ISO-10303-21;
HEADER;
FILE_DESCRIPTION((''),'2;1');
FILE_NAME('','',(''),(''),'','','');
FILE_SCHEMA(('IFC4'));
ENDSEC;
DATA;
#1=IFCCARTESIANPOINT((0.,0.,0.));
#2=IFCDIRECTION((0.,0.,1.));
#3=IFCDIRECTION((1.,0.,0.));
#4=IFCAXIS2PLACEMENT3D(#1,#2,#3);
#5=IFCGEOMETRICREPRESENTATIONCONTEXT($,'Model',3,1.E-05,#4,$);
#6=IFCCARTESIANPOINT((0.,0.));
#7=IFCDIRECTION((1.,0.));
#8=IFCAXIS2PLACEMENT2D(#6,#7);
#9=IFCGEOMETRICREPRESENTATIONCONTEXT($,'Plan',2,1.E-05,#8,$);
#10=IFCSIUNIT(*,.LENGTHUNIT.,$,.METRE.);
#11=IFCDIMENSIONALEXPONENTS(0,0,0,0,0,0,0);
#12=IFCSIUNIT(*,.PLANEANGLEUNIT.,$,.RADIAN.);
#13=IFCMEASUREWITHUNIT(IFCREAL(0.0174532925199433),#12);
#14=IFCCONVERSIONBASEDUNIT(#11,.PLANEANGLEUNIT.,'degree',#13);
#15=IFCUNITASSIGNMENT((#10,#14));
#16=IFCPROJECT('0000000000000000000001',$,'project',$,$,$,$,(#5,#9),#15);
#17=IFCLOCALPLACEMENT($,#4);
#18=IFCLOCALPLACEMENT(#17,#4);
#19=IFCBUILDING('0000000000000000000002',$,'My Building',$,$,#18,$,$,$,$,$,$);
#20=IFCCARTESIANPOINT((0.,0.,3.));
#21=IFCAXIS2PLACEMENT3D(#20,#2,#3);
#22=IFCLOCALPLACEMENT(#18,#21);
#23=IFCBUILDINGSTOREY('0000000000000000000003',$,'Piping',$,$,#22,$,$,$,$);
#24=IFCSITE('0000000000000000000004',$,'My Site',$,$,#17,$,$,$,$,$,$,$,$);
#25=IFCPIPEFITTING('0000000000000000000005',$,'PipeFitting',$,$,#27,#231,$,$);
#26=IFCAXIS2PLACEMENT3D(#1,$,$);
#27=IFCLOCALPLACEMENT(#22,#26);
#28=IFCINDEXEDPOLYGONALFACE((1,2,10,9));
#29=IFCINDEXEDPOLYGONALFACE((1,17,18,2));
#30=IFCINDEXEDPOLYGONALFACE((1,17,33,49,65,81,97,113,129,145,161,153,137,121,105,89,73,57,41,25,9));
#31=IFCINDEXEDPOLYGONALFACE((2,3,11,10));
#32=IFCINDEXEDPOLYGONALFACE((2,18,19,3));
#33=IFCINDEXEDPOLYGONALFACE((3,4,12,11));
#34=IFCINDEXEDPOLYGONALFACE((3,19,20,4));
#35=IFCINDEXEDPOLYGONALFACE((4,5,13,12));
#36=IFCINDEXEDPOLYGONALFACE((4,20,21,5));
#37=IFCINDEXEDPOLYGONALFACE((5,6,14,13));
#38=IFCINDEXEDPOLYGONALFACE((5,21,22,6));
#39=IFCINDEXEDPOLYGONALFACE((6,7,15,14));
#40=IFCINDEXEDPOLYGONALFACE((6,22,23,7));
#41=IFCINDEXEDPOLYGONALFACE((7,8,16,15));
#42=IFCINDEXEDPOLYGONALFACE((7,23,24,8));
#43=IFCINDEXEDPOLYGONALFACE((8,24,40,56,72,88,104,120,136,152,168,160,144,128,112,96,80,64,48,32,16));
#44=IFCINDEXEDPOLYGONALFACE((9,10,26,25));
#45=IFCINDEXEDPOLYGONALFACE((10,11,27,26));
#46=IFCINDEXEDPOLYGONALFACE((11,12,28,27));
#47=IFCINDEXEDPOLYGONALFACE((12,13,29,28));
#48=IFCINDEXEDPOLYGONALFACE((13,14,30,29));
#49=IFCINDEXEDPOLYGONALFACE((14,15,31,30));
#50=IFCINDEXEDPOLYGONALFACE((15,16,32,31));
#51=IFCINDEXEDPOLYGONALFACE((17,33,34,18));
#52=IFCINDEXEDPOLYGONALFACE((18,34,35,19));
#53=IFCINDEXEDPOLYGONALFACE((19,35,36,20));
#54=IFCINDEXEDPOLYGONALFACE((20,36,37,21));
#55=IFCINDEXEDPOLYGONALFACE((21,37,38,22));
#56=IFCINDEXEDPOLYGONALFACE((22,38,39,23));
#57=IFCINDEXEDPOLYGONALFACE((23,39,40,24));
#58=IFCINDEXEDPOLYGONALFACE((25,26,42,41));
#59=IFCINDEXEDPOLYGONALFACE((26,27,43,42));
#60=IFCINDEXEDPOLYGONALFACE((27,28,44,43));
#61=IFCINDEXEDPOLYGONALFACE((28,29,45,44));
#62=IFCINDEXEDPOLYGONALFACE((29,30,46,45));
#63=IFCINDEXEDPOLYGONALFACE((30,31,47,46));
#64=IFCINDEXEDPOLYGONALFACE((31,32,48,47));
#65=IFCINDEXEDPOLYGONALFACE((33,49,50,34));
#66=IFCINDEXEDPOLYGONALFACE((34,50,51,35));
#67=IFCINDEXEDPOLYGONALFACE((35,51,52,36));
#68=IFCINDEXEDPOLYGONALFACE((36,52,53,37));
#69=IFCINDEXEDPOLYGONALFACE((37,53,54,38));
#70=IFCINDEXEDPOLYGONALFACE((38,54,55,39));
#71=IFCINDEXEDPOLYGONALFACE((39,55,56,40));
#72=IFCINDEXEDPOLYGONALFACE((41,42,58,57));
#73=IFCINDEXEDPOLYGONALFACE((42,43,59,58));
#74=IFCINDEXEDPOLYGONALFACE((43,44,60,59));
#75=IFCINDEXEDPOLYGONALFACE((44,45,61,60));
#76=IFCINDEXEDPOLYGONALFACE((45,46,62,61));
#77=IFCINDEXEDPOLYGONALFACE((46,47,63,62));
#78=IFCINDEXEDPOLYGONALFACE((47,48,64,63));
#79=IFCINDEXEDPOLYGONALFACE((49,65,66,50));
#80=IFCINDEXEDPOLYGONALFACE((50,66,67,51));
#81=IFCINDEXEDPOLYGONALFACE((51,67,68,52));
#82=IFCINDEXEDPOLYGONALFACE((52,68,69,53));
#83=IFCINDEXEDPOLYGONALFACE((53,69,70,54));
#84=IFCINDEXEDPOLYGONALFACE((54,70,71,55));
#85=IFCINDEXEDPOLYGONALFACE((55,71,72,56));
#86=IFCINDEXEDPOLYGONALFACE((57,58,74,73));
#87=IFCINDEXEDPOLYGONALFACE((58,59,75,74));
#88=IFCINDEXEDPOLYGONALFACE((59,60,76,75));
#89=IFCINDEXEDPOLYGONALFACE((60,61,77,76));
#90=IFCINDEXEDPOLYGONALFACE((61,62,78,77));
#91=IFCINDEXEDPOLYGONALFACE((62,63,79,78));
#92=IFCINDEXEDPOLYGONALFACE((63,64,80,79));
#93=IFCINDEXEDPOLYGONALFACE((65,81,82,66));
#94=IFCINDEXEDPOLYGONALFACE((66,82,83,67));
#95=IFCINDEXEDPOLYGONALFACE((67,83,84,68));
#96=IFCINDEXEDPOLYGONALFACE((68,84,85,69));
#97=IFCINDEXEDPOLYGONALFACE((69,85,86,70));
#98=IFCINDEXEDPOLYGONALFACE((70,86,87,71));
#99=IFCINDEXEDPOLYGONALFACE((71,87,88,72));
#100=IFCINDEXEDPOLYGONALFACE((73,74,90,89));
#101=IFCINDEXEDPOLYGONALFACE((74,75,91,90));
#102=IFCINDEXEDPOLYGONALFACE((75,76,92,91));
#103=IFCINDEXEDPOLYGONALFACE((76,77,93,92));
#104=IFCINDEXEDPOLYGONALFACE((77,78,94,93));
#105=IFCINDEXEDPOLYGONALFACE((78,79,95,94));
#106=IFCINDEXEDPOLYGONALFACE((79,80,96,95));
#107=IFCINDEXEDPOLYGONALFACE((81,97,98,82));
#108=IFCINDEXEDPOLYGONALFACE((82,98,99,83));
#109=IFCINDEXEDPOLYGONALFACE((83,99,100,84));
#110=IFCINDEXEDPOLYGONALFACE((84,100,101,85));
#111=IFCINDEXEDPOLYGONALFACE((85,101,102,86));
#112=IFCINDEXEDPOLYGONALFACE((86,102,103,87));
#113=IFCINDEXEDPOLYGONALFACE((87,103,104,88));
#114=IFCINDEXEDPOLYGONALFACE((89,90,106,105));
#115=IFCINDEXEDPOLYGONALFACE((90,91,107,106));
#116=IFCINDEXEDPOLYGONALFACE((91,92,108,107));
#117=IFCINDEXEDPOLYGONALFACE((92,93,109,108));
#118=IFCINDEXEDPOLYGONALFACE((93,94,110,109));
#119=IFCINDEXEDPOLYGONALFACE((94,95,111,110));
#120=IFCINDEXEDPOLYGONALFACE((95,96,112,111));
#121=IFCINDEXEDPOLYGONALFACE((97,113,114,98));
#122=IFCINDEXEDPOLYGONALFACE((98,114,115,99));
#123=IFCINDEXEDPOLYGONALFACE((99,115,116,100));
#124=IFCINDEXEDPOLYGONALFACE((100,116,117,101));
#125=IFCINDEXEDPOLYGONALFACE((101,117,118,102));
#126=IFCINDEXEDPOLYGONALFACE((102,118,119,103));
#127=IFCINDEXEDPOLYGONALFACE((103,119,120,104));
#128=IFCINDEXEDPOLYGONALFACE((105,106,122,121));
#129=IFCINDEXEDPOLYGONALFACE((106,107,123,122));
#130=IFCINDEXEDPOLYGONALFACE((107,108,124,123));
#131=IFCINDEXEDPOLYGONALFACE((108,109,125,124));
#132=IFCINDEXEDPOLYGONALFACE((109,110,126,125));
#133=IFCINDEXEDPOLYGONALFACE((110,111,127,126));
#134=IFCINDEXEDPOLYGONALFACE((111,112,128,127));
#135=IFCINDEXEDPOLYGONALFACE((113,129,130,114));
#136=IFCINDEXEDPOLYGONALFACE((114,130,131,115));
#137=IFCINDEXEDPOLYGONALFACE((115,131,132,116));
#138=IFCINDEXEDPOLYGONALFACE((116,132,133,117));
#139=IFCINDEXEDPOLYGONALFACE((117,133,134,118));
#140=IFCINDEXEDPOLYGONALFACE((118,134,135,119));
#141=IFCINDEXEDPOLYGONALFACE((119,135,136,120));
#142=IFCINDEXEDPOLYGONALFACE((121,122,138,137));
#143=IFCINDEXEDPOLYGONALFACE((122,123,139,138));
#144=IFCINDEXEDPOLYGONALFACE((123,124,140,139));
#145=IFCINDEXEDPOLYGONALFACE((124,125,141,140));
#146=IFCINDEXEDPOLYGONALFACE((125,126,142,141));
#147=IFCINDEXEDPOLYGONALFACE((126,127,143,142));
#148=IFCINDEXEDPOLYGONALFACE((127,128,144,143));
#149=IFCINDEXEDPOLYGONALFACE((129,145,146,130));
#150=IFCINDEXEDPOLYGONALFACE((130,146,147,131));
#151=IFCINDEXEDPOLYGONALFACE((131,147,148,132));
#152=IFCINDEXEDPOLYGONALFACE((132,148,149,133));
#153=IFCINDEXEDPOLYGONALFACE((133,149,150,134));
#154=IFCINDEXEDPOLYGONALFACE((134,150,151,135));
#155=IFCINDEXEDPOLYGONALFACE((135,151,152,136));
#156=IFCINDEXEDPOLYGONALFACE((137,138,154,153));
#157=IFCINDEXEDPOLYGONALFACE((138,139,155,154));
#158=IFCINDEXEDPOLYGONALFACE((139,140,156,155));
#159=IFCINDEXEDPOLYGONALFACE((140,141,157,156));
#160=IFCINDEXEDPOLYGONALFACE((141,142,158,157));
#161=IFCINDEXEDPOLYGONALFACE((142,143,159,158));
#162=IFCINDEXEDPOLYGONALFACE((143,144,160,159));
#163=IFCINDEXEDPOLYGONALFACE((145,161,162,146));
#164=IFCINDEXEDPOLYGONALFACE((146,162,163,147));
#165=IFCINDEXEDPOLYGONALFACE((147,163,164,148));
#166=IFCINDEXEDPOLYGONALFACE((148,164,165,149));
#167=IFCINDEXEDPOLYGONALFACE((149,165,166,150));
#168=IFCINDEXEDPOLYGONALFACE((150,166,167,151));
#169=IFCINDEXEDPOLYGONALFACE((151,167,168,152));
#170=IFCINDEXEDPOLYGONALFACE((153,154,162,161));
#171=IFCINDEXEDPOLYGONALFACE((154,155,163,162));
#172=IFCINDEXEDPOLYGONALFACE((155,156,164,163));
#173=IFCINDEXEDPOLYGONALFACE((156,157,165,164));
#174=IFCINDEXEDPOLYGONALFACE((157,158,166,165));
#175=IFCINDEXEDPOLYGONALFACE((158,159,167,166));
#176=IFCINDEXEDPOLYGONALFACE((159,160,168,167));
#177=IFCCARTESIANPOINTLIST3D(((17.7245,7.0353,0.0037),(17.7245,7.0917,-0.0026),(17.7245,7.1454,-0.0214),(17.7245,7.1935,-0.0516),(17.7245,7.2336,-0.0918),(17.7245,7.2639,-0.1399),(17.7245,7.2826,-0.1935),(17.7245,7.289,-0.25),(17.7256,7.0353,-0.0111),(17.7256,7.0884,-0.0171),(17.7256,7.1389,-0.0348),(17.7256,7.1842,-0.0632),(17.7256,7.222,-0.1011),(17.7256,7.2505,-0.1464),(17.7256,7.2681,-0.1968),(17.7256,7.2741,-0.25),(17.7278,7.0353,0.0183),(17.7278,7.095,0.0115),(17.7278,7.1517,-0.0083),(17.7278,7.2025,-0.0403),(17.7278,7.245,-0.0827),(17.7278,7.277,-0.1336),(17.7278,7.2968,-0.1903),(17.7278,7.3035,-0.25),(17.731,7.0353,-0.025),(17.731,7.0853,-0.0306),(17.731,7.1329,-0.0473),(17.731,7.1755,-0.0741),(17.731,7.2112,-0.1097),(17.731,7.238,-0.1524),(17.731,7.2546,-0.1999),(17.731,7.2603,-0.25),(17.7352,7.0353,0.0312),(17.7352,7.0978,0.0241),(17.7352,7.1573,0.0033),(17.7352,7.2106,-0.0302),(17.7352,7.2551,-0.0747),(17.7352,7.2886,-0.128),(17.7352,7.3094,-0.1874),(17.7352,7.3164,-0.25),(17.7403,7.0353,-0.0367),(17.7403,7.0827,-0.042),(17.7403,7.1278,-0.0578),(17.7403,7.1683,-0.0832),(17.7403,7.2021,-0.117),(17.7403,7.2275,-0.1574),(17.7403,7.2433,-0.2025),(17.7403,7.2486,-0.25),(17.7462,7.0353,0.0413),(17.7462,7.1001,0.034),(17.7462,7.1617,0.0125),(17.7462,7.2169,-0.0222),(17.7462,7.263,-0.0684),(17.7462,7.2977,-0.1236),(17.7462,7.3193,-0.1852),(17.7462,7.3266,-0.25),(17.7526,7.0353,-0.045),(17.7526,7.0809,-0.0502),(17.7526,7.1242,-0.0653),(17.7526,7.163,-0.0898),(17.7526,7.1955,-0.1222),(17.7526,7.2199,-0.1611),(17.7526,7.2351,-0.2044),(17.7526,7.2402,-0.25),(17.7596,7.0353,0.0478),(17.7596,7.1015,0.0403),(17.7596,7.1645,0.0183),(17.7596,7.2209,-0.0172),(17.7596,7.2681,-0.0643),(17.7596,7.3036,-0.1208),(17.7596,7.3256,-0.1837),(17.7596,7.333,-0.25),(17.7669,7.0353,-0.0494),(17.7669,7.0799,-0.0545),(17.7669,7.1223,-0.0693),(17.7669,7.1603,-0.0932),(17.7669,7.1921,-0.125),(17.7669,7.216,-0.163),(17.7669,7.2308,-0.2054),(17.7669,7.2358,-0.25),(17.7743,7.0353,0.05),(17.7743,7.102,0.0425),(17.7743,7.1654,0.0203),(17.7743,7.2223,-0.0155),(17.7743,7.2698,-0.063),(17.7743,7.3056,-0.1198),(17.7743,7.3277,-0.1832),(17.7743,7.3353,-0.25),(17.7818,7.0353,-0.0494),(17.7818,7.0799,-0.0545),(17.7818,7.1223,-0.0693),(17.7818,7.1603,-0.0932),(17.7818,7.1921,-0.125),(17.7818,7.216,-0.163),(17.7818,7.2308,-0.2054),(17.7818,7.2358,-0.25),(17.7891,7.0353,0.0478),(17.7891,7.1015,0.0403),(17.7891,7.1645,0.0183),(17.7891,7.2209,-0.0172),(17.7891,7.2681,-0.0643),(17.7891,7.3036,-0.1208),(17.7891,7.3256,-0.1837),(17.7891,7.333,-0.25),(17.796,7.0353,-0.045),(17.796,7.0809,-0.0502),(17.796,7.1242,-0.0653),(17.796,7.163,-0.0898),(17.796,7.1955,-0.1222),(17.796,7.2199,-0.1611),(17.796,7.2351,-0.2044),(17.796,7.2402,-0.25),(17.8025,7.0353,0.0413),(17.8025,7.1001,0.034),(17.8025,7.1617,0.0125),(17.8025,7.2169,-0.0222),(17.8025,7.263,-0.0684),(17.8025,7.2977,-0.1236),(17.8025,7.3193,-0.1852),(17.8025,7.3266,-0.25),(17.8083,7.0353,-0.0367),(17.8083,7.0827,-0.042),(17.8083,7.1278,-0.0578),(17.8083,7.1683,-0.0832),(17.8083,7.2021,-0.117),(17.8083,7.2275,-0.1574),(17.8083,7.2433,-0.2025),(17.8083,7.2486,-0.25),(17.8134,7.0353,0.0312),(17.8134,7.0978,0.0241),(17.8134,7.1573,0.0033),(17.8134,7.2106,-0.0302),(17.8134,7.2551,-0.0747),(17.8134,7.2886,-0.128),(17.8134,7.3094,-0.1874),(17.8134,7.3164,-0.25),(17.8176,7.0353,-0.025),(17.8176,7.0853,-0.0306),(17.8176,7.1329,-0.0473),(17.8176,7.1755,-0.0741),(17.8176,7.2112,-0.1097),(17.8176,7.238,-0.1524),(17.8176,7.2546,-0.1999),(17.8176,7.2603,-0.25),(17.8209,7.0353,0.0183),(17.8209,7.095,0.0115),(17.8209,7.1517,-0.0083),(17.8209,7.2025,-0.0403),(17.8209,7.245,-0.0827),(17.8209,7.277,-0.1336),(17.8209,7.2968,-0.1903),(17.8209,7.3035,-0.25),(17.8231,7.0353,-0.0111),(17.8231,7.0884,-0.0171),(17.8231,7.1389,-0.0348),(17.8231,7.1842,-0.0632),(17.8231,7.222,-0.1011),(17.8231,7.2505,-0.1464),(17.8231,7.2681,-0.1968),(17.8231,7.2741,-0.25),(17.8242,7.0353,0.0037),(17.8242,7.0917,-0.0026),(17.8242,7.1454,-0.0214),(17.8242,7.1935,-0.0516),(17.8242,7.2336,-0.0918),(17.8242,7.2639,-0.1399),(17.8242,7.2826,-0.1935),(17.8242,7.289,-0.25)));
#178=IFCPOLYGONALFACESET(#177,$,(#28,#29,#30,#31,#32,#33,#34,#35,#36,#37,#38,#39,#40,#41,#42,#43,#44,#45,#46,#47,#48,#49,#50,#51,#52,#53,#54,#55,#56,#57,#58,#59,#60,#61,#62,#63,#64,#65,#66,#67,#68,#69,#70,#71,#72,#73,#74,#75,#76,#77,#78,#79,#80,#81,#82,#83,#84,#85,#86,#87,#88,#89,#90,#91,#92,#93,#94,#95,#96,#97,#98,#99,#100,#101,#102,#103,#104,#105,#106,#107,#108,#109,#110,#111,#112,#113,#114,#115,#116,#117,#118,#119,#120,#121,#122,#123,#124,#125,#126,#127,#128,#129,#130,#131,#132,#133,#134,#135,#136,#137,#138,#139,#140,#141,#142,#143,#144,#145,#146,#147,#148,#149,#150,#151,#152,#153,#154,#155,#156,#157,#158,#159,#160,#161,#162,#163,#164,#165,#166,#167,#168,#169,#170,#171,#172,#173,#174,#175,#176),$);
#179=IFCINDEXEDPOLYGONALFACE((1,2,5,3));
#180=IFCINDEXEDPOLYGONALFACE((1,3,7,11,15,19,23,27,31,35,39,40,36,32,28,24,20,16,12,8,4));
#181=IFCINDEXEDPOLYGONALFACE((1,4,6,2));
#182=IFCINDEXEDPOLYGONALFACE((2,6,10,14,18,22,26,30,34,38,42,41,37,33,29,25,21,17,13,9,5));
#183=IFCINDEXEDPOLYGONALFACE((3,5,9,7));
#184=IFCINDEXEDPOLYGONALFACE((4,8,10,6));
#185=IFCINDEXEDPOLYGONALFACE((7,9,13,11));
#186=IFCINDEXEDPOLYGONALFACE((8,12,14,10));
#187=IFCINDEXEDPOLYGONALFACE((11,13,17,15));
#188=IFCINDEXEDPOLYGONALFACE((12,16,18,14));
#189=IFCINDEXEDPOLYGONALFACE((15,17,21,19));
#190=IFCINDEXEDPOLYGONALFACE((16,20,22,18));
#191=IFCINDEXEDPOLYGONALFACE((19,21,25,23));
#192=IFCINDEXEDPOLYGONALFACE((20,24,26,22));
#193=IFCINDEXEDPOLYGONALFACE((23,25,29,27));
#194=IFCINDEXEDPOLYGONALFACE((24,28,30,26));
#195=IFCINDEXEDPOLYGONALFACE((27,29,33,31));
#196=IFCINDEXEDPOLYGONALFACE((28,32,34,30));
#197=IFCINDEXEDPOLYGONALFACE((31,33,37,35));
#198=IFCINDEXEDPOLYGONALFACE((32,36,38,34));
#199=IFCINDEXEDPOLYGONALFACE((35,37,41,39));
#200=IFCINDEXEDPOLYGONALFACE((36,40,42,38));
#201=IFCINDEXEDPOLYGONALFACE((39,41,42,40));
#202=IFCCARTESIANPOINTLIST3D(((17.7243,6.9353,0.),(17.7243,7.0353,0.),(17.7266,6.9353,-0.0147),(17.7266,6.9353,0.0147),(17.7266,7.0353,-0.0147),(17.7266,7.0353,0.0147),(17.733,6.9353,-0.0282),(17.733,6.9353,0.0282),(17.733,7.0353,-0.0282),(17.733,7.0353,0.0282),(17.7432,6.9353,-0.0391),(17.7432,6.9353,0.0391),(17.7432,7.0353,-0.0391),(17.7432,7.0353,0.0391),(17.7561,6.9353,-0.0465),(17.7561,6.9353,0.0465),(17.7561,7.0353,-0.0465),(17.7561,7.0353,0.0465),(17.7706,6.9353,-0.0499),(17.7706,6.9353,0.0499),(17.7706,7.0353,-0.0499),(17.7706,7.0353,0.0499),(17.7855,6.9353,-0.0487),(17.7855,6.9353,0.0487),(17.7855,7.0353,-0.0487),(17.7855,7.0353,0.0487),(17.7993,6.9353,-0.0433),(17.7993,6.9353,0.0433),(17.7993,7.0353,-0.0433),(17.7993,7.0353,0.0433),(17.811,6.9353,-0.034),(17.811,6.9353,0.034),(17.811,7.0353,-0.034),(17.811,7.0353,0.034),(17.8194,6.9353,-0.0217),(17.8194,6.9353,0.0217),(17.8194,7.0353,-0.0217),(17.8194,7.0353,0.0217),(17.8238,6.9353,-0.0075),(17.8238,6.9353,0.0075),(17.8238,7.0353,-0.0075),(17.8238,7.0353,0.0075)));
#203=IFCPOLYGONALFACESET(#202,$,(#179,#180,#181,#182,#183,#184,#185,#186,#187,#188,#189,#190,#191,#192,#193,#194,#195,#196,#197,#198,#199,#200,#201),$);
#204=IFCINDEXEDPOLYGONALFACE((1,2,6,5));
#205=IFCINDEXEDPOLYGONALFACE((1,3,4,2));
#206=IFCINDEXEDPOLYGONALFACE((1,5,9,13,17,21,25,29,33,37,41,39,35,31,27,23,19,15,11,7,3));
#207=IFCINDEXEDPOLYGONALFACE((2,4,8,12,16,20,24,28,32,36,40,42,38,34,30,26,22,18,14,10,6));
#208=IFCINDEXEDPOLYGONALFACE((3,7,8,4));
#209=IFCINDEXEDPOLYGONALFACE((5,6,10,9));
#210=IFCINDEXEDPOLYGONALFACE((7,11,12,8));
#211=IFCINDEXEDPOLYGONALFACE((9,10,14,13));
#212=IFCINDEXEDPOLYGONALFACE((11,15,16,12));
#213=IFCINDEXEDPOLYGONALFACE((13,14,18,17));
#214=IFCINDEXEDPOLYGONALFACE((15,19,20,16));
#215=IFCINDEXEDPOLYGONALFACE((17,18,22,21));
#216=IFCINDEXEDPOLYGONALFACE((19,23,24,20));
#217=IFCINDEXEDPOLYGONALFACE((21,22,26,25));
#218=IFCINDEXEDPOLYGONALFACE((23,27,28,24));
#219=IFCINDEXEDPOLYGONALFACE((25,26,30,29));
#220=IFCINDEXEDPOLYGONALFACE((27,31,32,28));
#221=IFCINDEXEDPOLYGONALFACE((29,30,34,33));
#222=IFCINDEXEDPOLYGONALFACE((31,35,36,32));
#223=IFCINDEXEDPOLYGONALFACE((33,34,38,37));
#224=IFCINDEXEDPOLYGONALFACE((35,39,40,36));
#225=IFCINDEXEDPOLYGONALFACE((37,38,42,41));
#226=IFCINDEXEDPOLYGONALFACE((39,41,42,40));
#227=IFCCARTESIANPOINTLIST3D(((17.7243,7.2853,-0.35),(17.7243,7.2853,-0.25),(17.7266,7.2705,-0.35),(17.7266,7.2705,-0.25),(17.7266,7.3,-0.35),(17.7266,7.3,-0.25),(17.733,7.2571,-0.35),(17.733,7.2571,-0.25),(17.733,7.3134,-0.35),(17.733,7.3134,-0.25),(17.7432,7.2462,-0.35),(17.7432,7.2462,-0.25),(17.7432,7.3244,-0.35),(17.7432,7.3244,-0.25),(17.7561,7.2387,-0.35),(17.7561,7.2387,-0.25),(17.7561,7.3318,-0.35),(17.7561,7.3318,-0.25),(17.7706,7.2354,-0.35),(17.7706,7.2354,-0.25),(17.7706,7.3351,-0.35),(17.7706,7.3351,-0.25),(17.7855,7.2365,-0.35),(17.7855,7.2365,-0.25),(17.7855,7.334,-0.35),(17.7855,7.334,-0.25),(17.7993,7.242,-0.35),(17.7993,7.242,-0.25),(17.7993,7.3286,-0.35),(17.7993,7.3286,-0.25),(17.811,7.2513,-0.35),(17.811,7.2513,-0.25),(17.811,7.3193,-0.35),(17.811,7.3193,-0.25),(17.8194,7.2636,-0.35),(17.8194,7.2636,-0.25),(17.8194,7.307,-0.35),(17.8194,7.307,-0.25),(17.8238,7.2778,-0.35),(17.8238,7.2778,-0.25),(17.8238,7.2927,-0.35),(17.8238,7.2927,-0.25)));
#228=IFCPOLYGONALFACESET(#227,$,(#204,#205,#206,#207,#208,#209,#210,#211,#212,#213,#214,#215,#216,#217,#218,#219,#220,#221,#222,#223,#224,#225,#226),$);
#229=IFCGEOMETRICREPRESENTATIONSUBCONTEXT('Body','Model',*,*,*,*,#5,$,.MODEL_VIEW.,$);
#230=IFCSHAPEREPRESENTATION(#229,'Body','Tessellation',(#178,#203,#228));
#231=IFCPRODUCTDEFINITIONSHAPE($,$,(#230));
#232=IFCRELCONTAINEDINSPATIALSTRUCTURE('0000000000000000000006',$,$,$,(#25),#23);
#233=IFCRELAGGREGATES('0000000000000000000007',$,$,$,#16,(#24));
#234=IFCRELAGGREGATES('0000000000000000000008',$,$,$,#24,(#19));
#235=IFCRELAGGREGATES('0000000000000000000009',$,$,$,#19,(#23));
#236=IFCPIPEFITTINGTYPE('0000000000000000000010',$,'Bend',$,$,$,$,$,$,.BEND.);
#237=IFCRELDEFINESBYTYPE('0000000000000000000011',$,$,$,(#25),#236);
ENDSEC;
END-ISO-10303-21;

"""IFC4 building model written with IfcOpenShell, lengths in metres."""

from ifc_helpers import new_model, entity, si_unit, converted_unit, frame, origin_with_axes, origin_2d_with_axis, place, context, subcontext, project, spatial, circle, extrude, source, transform, mapped, type_object, type_shapes, element, save


model = new_model("IFC4")

# Units and contexts
model_context = context("Model", 3, precision=1e-05, world=origin_with_axes())
plan_context = context("Plan", 2, precision=1e-05, world=origin_2d_with_axis())
body_context = subcontext(model_context, "Body", "Model", "MODEL_VIEW")
ifc_project = project(units=[si_unit("LENGTHUNIT", "METRE"), converted_unit("PLANEANGLEUNIT", "degree", entity("IfcReal", 0.0174532925199433), si_unit("PLANEANGLEUNIT", "RADIAN"), dimensions=[0, 0, 0, 0, 0, 0, 0])], contexts=[model_context, plan_context])

# Site, building, storey
site_placement = place(None, origin_with_axes())
site = spatial("IfcSite", under=ifc_project, at=site_placement, Name="My Site")
building_placement = place(site_placement, origin_with_axes())
building = spatial("IfcBuilding", under=site, at=building_placement, Name="My Building")
storey_placement = place(building_placement, frame((0.0, 0.0, 3.0), z_axis=(0.0, 0.0, 1.0), x_axis=(1.0, 0.0, 0.0)))
storey = spatial("IfcBuildingStorey", under=building, at=storey_placement, Name="Piping")

# Pipe fitting
pipe_fitting_type_1 = type_object("IfcPipeFittingType", Name="Bend", PredefinedType="BEND")
shared_shape = source(origin_with_axes(), body_context, "Body", "SolidModel", [
    entity("IfcSweptDiskSolid", entity("IfcIndexedPolyCurve", entity("IfcCartesianPointList3D", [[0.0, 0.0, -0.1], [0.0, 0.0732, -0.2768], [0.0, 0.25, -0.35]]), [entity("IfcArcIndex", [1, 2, 3])]), 0.05),
    extrude(circle(Radius=0.05), origin_with_axes(), (0.0, 0.0, -1.0), 0.1),
    extrude(circle(Radius=0.05), frame((0.0, 0.25, -0.35), z_axis=(0.0, 1.0, 0.0), x_axis=(1.0, 0.0, 0.0)), (0.0, 0.0, 1.0), 0.1),
])
type_shapes(pipe_fitting_type_1, [shared_shape])
for number, where, z_axis, x_axis, name in (
    (1, (17.7743, 6.9353, 0.0), (0.0, -1.0, 0.0), (-1.0, 0.0, 0.0), "PipeFitting"),
):
    element("IfcPipeFitting", number, at=place(storey_placement, frame(where, z_axis=z_axis, x_axis=x_axis)), inside=storey, type_object=pipe_fitting_type_1, Name=name, context=body_context, shape_type="MappedRepresentation", body=[
        mapped(shared_shape, transform((0.0, 0.0, 0.0), x_axis=(1.0, 0.0, 0.0), y_axis=(0.0, 1.0, 0.0), z_axis=(0.0, 0.0, 1.0), scale=1.0)),
    ])

save(model, "model.ifc")
